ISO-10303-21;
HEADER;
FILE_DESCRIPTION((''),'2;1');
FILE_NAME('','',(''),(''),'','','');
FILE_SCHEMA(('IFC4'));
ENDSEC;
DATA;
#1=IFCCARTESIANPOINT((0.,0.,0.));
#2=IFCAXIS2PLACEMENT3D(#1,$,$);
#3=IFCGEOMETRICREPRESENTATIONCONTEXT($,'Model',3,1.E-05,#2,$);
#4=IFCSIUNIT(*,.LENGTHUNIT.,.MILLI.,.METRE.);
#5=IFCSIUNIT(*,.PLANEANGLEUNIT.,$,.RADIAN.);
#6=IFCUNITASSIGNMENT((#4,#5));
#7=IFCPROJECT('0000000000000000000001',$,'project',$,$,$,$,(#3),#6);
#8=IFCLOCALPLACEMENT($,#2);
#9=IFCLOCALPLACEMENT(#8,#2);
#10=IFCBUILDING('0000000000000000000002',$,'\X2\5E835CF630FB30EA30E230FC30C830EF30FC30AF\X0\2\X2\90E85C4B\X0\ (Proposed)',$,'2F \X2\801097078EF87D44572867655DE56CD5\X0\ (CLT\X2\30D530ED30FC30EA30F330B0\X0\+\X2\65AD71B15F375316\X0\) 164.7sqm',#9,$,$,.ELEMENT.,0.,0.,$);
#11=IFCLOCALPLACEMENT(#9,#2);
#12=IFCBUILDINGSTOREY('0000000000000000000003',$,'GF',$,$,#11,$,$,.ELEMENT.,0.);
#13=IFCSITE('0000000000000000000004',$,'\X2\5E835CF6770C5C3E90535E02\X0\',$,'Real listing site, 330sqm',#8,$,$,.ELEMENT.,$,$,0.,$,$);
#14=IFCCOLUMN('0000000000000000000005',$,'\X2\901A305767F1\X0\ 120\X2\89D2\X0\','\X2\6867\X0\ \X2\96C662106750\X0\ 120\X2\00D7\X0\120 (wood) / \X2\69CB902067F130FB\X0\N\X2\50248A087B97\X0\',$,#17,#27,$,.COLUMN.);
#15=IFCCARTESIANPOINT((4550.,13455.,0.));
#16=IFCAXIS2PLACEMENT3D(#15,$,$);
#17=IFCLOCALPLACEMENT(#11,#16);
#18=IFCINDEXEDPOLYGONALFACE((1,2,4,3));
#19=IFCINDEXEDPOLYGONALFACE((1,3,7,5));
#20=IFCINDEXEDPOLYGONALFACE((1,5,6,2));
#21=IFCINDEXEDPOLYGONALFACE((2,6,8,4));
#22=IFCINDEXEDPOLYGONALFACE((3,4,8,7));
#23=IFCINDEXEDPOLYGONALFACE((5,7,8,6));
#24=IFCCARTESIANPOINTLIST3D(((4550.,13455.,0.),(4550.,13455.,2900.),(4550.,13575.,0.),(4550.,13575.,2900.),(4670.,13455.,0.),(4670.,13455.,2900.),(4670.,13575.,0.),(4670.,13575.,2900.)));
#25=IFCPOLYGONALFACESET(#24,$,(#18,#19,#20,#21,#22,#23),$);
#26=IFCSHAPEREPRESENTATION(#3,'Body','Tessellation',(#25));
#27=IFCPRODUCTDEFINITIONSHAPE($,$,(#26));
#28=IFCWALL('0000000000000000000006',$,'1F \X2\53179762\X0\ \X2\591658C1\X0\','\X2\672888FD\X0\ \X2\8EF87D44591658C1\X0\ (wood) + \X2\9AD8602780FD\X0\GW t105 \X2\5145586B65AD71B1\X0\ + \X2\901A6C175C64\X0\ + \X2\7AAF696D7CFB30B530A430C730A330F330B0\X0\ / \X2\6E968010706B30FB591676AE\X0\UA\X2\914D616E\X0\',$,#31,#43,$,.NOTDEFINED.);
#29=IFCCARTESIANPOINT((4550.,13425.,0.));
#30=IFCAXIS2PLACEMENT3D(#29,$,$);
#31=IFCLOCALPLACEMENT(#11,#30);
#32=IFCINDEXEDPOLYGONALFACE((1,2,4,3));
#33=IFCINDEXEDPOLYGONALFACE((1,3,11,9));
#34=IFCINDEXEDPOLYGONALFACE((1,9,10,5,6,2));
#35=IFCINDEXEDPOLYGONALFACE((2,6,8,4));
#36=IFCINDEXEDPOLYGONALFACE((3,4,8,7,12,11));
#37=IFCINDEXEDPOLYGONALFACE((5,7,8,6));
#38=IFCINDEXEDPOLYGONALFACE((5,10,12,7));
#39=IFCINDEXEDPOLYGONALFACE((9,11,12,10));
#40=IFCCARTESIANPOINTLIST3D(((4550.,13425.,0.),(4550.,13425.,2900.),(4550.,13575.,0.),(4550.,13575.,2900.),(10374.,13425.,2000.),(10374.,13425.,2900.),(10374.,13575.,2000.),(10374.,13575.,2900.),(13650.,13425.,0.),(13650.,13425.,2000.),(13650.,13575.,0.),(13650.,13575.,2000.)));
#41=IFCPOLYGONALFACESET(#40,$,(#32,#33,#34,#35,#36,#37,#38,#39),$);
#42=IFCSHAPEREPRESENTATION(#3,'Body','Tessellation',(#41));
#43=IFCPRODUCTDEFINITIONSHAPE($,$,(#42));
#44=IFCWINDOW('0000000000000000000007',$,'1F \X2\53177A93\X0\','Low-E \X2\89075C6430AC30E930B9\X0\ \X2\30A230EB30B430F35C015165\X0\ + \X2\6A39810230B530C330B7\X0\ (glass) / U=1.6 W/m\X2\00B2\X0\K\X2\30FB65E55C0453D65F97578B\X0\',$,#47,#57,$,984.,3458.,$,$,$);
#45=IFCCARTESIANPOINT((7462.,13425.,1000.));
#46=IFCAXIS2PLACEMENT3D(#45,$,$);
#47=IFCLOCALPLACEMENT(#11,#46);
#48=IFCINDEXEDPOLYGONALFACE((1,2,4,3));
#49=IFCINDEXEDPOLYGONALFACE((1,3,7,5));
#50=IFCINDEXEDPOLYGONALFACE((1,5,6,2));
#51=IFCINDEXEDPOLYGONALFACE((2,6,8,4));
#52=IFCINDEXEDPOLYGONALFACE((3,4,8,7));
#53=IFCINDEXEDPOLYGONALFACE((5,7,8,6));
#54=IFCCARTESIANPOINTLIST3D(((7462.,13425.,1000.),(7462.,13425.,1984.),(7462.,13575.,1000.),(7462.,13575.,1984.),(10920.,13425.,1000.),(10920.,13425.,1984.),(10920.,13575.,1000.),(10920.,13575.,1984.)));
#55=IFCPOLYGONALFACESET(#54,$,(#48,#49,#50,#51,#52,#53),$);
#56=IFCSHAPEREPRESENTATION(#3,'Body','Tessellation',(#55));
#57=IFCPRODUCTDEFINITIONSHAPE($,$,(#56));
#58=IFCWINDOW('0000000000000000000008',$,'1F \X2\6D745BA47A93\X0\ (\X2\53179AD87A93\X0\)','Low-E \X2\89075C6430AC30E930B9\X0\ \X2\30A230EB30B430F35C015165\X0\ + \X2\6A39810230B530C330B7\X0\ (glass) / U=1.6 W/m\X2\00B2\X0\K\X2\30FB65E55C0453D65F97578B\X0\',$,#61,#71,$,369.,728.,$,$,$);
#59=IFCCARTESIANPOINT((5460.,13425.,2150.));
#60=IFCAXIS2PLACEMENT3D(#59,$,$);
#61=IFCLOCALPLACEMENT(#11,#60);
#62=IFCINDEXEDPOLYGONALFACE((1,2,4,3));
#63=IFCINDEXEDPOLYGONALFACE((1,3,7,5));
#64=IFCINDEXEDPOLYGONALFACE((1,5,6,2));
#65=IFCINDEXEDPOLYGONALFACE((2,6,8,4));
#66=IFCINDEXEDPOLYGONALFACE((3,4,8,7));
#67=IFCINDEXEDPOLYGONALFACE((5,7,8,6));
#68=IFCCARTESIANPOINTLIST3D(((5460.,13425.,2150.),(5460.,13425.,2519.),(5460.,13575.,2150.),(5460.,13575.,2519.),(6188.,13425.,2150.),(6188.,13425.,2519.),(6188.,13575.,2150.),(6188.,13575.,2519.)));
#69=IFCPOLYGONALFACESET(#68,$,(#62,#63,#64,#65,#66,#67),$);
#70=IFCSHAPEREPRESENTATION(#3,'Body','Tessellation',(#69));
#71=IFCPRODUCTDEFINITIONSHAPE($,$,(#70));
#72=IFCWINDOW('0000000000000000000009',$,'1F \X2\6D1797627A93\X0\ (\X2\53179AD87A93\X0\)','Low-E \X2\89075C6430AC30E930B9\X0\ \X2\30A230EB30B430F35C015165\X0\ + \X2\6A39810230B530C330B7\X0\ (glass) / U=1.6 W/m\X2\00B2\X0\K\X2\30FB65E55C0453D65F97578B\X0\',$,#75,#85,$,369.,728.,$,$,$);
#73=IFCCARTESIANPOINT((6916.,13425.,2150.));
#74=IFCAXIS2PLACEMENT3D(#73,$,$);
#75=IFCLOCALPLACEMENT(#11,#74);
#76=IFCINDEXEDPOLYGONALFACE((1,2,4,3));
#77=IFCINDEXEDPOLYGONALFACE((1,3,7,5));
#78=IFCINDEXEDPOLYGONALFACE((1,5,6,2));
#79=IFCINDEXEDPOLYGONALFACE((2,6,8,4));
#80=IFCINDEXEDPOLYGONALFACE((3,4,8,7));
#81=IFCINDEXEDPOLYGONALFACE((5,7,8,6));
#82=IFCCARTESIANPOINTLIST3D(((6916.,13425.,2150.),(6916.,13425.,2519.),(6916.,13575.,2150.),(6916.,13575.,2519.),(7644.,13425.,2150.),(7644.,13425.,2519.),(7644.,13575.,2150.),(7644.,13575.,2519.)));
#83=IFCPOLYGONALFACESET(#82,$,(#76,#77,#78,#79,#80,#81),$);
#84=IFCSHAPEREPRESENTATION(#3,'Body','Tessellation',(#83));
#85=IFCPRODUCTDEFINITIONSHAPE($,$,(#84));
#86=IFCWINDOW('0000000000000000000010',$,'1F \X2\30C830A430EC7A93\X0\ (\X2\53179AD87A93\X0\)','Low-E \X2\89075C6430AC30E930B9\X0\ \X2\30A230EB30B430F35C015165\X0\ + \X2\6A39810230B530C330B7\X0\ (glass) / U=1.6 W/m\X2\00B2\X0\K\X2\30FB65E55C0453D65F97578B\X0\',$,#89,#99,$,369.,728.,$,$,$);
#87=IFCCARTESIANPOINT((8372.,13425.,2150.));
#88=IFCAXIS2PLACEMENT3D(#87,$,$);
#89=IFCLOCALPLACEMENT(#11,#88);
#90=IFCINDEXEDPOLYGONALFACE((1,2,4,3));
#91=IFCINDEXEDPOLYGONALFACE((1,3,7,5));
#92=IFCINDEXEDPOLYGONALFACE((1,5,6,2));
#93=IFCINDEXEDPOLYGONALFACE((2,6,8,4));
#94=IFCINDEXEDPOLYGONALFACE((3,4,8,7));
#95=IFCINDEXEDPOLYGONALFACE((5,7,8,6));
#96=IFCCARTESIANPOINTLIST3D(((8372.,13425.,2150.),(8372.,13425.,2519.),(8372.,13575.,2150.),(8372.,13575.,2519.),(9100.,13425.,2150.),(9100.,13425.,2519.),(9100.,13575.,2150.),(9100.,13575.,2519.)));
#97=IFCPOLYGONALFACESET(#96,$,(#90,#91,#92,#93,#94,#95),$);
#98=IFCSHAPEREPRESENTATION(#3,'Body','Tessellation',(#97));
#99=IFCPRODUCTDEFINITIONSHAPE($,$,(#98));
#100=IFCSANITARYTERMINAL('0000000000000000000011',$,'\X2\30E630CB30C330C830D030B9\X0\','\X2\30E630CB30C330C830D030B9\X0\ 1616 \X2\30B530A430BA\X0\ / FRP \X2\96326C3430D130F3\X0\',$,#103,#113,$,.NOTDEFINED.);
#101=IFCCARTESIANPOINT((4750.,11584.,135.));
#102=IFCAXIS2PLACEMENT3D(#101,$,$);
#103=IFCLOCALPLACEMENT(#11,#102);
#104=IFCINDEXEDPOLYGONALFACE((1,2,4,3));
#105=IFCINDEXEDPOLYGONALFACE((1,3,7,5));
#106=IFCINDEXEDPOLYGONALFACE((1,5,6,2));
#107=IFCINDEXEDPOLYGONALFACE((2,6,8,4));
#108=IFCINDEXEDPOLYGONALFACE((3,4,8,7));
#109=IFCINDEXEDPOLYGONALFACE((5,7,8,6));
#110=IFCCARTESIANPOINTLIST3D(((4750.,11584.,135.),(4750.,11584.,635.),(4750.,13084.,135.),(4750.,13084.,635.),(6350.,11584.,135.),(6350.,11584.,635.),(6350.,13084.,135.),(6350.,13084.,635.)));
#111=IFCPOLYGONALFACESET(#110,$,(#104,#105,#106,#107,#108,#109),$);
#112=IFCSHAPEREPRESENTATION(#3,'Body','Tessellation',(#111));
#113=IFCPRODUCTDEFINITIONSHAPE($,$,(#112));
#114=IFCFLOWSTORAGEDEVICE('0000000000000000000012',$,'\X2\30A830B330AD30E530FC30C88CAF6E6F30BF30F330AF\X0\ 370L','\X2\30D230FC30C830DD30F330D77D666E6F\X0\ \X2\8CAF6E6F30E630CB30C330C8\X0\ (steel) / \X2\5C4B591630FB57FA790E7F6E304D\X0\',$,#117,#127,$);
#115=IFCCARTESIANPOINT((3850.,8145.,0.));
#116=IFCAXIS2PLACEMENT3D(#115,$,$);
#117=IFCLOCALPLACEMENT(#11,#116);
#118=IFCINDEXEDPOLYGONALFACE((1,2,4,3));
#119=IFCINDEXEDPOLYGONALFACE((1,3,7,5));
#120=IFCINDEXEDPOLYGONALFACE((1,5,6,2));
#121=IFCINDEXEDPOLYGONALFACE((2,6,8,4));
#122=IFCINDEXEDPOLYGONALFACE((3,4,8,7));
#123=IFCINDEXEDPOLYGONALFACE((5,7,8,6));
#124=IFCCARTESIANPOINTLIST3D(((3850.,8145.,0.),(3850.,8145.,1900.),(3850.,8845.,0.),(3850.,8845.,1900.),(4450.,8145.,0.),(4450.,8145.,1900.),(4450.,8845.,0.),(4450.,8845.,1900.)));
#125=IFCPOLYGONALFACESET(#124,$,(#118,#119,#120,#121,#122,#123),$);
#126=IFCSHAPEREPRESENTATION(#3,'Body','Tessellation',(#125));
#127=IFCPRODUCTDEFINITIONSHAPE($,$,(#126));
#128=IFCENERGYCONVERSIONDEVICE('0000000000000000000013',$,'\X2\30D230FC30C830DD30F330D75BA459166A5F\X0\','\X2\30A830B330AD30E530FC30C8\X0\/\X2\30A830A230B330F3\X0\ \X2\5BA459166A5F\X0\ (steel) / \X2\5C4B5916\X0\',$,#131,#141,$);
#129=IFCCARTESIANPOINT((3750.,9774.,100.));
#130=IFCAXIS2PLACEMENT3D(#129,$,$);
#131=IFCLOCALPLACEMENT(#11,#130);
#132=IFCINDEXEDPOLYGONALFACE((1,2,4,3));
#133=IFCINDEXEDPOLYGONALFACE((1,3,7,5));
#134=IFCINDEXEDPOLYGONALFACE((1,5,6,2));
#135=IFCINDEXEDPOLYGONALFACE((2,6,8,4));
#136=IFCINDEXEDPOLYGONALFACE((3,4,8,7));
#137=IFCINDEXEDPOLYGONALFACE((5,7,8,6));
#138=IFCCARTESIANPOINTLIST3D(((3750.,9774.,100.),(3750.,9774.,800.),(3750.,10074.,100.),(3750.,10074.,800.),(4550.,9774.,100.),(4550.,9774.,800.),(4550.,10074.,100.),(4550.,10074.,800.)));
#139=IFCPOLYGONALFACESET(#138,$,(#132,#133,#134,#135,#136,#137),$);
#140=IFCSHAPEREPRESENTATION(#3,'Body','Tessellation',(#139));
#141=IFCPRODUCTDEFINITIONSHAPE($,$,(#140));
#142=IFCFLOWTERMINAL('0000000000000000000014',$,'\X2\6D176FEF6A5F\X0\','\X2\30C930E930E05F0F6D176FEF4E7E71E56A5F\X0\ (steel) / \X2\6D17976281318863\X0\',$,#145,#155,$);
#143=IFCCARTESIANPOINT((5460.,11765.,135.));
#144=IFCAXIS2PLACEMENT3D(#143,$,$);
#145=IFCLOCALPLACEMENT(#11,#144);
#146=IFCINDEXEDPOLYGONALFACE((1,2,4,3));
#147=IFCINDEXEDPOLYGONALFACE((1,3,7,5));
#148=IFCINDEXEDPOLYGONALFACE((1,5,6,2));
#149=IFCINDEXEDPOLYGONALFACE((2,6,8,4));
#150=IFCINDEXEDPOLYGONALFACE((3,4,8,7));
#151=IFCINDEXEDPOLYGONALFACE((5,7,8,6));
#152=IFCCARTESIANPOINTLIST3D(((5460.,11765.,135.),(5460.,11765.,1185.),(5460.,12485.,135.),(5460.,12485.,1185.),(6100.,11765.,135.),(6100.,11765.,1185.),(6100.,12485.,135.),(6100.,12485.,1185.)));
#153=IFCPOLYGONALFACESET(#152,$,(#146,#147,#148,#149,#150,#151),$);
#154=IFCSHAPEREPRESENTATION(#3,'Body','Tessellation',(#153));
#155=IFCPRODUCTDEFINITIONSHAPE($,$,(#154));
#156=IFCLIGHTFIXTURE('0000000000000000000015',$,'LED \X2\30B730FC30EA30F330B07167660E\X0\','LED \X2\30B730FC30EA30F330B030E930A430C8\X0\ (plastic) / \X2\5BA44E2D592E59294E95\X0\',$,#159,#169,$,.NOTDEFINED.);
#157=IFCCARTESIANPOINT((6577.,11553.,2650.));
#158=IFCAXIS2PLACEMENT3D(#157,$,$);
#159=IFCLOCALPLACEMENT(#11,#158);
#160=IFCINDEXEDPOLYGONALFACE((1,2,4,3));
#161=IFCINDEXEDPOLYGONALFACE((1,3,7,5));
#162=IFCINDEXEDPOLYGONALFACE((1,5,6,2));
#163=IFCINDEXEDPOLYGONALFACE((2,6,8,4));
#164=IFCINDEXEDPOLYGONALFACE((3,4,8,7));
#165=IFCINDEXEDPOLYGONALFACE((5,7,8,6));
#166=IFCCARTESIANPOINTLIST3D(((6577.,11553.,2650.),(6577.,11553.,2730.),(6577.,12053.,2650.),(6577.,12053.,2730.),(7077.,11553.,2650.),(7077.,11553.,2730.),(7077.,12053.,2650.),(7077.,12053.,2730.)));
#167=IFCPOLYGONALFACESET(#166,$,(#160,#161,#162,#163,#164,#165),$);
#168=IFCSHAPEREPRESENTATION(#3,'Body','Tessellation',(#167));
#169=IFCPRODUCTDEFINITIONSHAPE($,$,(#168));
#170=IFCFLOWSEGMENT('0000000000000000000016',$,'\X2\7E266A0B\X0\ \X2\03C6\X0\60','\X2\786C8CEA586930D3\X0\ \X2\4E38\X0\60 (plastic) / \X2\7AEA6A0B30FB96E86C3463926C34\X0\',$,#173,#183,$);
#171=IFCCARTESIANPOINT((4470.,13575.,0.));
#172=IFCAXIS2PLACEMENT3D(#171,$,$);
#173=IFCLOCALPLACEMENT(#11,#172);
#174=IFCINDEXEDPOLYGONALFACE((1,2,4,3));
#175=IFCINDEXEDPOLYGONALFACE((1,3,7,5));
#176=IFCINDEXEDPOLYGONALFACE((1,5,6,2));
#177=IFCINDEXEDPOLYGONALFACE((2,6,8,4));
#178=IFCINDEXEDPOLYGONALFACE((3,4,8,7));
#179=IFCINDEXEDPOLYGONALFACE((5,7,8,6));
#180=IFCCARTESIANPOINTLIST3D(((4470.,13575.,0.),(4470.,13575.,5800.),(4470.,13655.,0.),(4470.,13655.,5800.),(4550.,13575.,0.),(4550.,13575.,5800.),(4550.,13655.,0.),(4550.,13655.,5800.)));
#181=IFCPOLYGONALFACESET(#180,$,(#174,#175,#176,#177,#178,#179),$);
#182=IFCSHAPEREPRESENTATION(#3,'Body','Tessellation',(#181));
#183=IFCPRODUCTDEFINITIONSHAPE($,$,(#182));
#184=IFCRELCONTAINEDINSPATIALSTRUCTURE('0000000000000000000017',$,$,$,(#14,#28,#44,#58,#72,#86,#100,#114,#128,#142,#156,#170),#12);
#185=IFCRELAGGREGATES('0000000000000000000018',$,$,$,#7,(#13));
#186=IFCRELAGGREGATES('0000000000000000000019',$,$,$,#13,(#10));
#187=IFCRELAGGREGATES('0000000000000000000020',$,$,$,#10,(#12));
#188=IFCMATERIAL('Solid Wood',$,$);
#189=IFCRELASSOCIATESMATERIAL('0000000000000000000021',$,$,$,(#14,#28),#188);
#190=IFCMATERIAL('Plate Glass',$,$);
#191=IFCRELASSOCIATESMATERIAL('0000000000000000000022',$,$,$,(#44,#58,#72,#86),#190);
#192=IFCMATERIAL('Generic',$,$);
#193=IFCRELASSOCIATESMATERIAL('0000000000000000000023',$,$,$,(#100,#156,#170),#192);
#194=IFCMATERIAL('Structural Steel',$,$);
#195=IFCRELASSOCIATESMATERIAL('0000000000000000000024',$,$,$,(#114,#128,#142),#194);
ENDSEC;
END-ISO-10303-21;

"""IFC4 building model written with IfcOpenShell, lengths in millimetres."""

from ifc_helpers import new_model, si_unit, frame, frame_2d, origin, place, context, project, spatial, rectangle, extrude, material, element, fill, save


model = new_model("IFC4")

# Units and contexts
model_context = context("Model", 3, precision=1e-05, world=origin())
ifc_project = project(units=[si_unit("LENGTHUNIT", "METRE", prefix="MILLI"), si_unit("PLANEANGLEUNIT", "RADIAN")], contexts=[model_context])

# Site, building, storey
site_placement = place(None, origin())
site = spatial("IfcSite", under=ifc_project, at=site_placement, Name="広島県尾道市", ObjectType="Real listing site, 330sqm", CompositionType="ELEMENT", RefElevation=0.0)
building_placement = place(site_placement, origin())
building = spatial("IfcBuilding", under=site, at=building_placement, Name="広島・リモートワーク2部屋 (Proposed)", ObjectType="2F 耐震軸組在来工法 (CLTフローリング+断熱強化) 164.7sqm", CompositionType="ELEMENT", ElevationOfRefHeight=0.0, ElevationOfTerrain=0.0)
storey_placement = place(building_placement, origin())
storey = spatial("IfcBuildingStorey", under=building, at=storey_placement, Name="GF", CompositionType="ELEMENT", Elevation=0.0)

# Column
ifc_material_1 = material(Name="Solid Wood")
column_1_placement = place(storey_placement, frame((4550.0, 13455.0, 0.0)))
element("IfcColumn", 1, at=column_1_placement, inside=storey, material=ifc_material_1, Name="通し柱 120角", Description="桧 集成材 120×120 (wood) / 構造柱・N値計算", PredefinedType="COLUMN", context=model_context, shape_type="SweptSolid", body=[
    extrude(rectangle(XDim=120.0, YDim=120.0, at=frame_2d((60.0, 60.0))), frame((4550.0, 13455.0, 0.0)), (0.0, 0.0, 1.0), 2900.0),
])

# Wall, openings, windows
wall_1_placement = place(storey_placement, frame((4550.0, 13425.0, 0.0)))
wall_1 = element("IfcWall", 2, at=wall_1_placement, inside=storey, material=ifc_material_1, Name="1F 北面 外壁", Description="木製 軸組外壁 (wood) + 高性能GW t105 充填断熱 + 通気層 + 窯業系サイディング / 準耐火・外皮UA配慮", PredefinedType="NOTDEFINED", context=model_context, shape_type="SweptSolid", body=[
    extrude(rectangle(XDim=9100.0, YDim=150.0, at=frame_2d((4550.0, 75.0))), frame((4550.0, 13425.0, 0.0)), (0.0, 0.0, 1.0), 2900.0),
])
opening_1_placement = place(storey_placement, frame((7462.0, 13425.0, 1000.0)))
opening_1 = element("IfcOpeningElement", 3, at=opening_1_placement, cuts=wall_1, PredefinedType="NOTDEFINED", context=model_context, shape_type="SweptSolid", body=[
    extrude(rectangle(XDim=3458.0, YDim=150.0, at=frame_2d((1729.0, 75.0))), frame((7462.0, 13425.0, 1000.0)), (0.0, 0.0, 1.0), 984.0),
])
opening_2_placement = place(storey_placement, frame((5460.0, 13425.0, 2150.0)))
opening_2 = element("IfcOpeningElement", 4, at=opening_2_placement, cuts=wall_1, PredefinedType="NOTDEFINED", context=model_context, shape_type="SweptSolid", body=[
    extrude(rectangle(XDim=728.0, YDim=150.0, at=frame_2d((364.0, 75.0))), frame((5460.0, 13425.0, 2150.0)), (0.0, 0.0, 1.0), 369.0),
])
opening_3_placement = place(storey_placement, frame((6916.0, 13425.0, 2150.0)))
opening_3 = element("IfcOpeningElement", 5, at=opening_3_placement, cuts=wall_1, PredefinedType="NOTDEFINED", context=model_context, shape_type="SweptSolid", body=[
    extrude(rectangle(XDim=728.0, YDim=150.0, at=frame_2d((364.0, 75.0))), frame((6916.0, 13425.0, 2150.0)), (0.0, 0.0, 1.0), 369.0),
])
opening_4_placement = place(storey_placement, frame((8372.0, 13425.0, 2150.0)))
opening_4 = element("IfcOpeningElement", 6, at=opening_4_placement, cuts=wall_1, PredefinedType="NOTDEFINED", context=model_context, shape_type="SweptSolid", body=[
    extrude(rectangle(XDim=728.0, YDim=150.0, at=frame_2d((364.0, 75.0))), frame((8372.0, 13425.0, 2150.0)), (0.0, 0.0, 1.0), 369.0),
])
ifc_material_2 = material(Name="Plate Glass")
window_1_placement = place(storey_placement, frame((7462.0, 13425.0, 1000.0)))
window_1 = element("IfcWindow", 7, at=window_1_placement, inside=storey, material=ifc_material_2, Name="1F 北窓", Description="Low-E 複層ガラス アルゴン封入 + 樹脂サッシ (glass) / U=1.6 W/m²K・日射取得型", OverallHeight=984.0, OverallWidth=3458.0, context=model_context, shape_type="SweptSolid", body=[
    extrude(rectangle(XDim=3458.0, YDim=150.0, at=frame_2d((1729.0, 75.0))), frame((7462.0, 13425.0, 1000.0)), (0.0, 0.0, 1.0), 984.0),
])
fill(opening_1, window_1)
window_2_placement = place(storey_placement, frame((5460.0, 13425.0, 2150.0)))
window_2 = element("IfcWindow", 8, at=window_2_placement, inside=storey, material=ifc_material_2, Name="1F 浴室窓 (北高窓)", Description="Low-E 複層ガラス アルゴン封入 + 樹脂サッシ (glass) / U=1.6 W/m²K・日射取得型", OverallHeight=369.0, OverallWidth=728.0, context=model_context, shape_type="SweptSolid", body=[
    extrude(rectangle(XDim=728.0, YDim=150.0, at=frame_2d((364.0, 75.0))), frame((5460.0, 13425.0, 2150.0)), (0.0, 0.0, 1.0), 369.0),
])
fill(opening_2, window_2)
window_3_placement = place(storey_placement, frame((6916.0, 13425.0, 2150.0)))
window_3 = element("IfcWindow", 9, at=window_3_placement, inside=storey, material=ifc_material_2, Name="1F 洗面窓 (北高窓)", Description="Low-E 複層ガラス アルゴン封入 + 樹脂サッシ (glass) / U=1.6 W/m²K・日射取得型", OverallHeight=369.0, OverallWidth=728.0, context=model_context, shape_type="SweptSolid", body=[
    extrude(rectangle(XDim=728.0, YDim=150.0, at=frame_2d((364.0, 75.0))), frame((6916.0, 13425.0, 2150.0)), (0.0, 0.0, 1.0), 369.0),
])
fill(opening_3, window_3)
window_4_placement = place(storey_placement, frame((8372.0, 13425.0, 2150.0)))
window_4 = element("IfcWindow", 10, at=window_4_placement, inside=storey, material=ifc_material_2, Name="1F トイレ窓 (北高窓)", Description="Low-E 複層ガラス アルゴン封入 + 樹脂サッシ (glass) / U=1.6 W/m²K・日射取得型", OverallHeight=369.0, OverallWidth=728.0, context=model_context, shape_type="SweptSolid", body=[
    extrude(rectangle(XDim=728.0, YDim=150.0, at=frame_2d((364.0, 75.0))), frame((8372.0, 13425.0, 2150.0)), (0.0, 0.0, 1.0), 369.0),
])
fill(opening_4, window_4)

# Sanitary terminal
ifc_material_3 = material(Name="Generic")
sanitary_terminal_placement = place(storey_placement, frame((4750.0, 11584.0, 135.0)))
element("IfcSanitaryTerminal", 11, at=sanitary_terminal_placement, inside=storey, material=ifc_material_3, Name="ユニットバス", Description="ユニットバス 1616 サイズ / FRP 防水パン", PredefinedType="NOTDEFINED", context=model_context, shape_type="SweptSolid", body=[
    extrude(rectangle(XDim=1600.0, YDim=1500.0, at=frame_2d((800.0, 750.0))), frame((4750.0, 11584.0, 135.0)), (0.0, 0.0, 1.0), 500.0),
])

# Flow storage device
ifc_material_4 = material(Name="Structural Steel")
flow_storage_device_placement = place(storey_placement, frame((3850.0, 8145.0, 0.0)))
element("IfcFlowStorageDevice", 12, at=flow_storage_device_placement, inside=storey, material=ifc_material_4, Name="エコキュート貯湯タンク 370L", Description="ヒートポンプ給湯 貯湯ユニット (steel) / 屋外・基礎置き", context=model_context, shape_type="SweptSolid", body=[
    extrude(rectangle(XDim=600.0, YDim=700.0, at=frame_2d((300.0, 350.0))), frame((3850.0, 8145.0, 0.0)), (0.0, 0.0, 1.0), 1900.0),
])

# Energy conversion device
energy_conversion_device_placement = place(storey_placement, frame((3750.0, 9774.0, 100.0)))
element("IfcEnergyConversionDevice", 13, at=energy_conversion_device_placement, inside=storey, material=ifc_material_4, Name="ヒートポンプ室外機", Description="エコキュート/エアコン 室外機 (steel) / 屋外", context=model_context, shape_type="SweptSolid", body=[
    extrude(rectangle(XDim=800.0, YDim=300.0, at=frame_2d((400.0, 150.0))), frame((3750.0, 9774.0, 100.0)), (0.0, 0.0, 1.0), 700.0),
])

# Flow terminal
flow_terminal_placement = place(storey_placement, frame((5460.0, 11765.0, 135.0)))
element("IfcFlowTerminal", 14, at=flow_terminal_placement, inside=storey, material=ifc_material_4, Name="洗濯機", Description="ドラム式洗濯乾燥機 (steel) / 洗面脱衣", context=model_context, shape_type="SweptSolid", body=[
    extrude(rectangle(XDim=640.0, YDim=720.0, at=frame_2d((320.0, 360.0))), frame((5460.0, 11765.0, 135.0)), (0.0, 0.0, 1.0), 1050.0),
])

# Light fixture
light_fixture_placement = place(storey_placement, frame((6577.0, 11553.0, 2650.0)))
element("IfcLightFixture", 15, at=light_fixture_placement, inside=storey, material=ifc_material_3, Name="LED シーリング照明", Description="LED シーリングライト (plastic) / 室中央天井", PredefinedType="NOTDEFINED", context=model_context, shape_type="SweptSolid", body=[
    extrude(rectangle(XDim=500.0, YDim=500.0, at=frame_2d((250.0, 250.0))), frame((6577.0, 11553.0, 2650.0)), (0.0, 0.0, 1.0), 80.0),
])

# Flow segment
flow_segment_placement = place(storey_placement, frame((4470.0, 13575.0, 0.0)))
element("IfcFlowSegment", 16, at=flow_segment_placement, inside=storey, material=ifc_material_3, Name="縦樋 φ60", Description="硬質塩ビ 丸60 (plastic) / 竪樋・雨水排水", context=model_context, shape_type="SweptSolid", body=[
    extrude(rectangle(XDim=80.0, YDim=80.0, at=frame_2d((40.0, 40.0))), frame((4470.0, 13575.0, 0.0)), (0.0, 0.0, 1.0), 5800.0),
])

save(model, "model.ifc")
